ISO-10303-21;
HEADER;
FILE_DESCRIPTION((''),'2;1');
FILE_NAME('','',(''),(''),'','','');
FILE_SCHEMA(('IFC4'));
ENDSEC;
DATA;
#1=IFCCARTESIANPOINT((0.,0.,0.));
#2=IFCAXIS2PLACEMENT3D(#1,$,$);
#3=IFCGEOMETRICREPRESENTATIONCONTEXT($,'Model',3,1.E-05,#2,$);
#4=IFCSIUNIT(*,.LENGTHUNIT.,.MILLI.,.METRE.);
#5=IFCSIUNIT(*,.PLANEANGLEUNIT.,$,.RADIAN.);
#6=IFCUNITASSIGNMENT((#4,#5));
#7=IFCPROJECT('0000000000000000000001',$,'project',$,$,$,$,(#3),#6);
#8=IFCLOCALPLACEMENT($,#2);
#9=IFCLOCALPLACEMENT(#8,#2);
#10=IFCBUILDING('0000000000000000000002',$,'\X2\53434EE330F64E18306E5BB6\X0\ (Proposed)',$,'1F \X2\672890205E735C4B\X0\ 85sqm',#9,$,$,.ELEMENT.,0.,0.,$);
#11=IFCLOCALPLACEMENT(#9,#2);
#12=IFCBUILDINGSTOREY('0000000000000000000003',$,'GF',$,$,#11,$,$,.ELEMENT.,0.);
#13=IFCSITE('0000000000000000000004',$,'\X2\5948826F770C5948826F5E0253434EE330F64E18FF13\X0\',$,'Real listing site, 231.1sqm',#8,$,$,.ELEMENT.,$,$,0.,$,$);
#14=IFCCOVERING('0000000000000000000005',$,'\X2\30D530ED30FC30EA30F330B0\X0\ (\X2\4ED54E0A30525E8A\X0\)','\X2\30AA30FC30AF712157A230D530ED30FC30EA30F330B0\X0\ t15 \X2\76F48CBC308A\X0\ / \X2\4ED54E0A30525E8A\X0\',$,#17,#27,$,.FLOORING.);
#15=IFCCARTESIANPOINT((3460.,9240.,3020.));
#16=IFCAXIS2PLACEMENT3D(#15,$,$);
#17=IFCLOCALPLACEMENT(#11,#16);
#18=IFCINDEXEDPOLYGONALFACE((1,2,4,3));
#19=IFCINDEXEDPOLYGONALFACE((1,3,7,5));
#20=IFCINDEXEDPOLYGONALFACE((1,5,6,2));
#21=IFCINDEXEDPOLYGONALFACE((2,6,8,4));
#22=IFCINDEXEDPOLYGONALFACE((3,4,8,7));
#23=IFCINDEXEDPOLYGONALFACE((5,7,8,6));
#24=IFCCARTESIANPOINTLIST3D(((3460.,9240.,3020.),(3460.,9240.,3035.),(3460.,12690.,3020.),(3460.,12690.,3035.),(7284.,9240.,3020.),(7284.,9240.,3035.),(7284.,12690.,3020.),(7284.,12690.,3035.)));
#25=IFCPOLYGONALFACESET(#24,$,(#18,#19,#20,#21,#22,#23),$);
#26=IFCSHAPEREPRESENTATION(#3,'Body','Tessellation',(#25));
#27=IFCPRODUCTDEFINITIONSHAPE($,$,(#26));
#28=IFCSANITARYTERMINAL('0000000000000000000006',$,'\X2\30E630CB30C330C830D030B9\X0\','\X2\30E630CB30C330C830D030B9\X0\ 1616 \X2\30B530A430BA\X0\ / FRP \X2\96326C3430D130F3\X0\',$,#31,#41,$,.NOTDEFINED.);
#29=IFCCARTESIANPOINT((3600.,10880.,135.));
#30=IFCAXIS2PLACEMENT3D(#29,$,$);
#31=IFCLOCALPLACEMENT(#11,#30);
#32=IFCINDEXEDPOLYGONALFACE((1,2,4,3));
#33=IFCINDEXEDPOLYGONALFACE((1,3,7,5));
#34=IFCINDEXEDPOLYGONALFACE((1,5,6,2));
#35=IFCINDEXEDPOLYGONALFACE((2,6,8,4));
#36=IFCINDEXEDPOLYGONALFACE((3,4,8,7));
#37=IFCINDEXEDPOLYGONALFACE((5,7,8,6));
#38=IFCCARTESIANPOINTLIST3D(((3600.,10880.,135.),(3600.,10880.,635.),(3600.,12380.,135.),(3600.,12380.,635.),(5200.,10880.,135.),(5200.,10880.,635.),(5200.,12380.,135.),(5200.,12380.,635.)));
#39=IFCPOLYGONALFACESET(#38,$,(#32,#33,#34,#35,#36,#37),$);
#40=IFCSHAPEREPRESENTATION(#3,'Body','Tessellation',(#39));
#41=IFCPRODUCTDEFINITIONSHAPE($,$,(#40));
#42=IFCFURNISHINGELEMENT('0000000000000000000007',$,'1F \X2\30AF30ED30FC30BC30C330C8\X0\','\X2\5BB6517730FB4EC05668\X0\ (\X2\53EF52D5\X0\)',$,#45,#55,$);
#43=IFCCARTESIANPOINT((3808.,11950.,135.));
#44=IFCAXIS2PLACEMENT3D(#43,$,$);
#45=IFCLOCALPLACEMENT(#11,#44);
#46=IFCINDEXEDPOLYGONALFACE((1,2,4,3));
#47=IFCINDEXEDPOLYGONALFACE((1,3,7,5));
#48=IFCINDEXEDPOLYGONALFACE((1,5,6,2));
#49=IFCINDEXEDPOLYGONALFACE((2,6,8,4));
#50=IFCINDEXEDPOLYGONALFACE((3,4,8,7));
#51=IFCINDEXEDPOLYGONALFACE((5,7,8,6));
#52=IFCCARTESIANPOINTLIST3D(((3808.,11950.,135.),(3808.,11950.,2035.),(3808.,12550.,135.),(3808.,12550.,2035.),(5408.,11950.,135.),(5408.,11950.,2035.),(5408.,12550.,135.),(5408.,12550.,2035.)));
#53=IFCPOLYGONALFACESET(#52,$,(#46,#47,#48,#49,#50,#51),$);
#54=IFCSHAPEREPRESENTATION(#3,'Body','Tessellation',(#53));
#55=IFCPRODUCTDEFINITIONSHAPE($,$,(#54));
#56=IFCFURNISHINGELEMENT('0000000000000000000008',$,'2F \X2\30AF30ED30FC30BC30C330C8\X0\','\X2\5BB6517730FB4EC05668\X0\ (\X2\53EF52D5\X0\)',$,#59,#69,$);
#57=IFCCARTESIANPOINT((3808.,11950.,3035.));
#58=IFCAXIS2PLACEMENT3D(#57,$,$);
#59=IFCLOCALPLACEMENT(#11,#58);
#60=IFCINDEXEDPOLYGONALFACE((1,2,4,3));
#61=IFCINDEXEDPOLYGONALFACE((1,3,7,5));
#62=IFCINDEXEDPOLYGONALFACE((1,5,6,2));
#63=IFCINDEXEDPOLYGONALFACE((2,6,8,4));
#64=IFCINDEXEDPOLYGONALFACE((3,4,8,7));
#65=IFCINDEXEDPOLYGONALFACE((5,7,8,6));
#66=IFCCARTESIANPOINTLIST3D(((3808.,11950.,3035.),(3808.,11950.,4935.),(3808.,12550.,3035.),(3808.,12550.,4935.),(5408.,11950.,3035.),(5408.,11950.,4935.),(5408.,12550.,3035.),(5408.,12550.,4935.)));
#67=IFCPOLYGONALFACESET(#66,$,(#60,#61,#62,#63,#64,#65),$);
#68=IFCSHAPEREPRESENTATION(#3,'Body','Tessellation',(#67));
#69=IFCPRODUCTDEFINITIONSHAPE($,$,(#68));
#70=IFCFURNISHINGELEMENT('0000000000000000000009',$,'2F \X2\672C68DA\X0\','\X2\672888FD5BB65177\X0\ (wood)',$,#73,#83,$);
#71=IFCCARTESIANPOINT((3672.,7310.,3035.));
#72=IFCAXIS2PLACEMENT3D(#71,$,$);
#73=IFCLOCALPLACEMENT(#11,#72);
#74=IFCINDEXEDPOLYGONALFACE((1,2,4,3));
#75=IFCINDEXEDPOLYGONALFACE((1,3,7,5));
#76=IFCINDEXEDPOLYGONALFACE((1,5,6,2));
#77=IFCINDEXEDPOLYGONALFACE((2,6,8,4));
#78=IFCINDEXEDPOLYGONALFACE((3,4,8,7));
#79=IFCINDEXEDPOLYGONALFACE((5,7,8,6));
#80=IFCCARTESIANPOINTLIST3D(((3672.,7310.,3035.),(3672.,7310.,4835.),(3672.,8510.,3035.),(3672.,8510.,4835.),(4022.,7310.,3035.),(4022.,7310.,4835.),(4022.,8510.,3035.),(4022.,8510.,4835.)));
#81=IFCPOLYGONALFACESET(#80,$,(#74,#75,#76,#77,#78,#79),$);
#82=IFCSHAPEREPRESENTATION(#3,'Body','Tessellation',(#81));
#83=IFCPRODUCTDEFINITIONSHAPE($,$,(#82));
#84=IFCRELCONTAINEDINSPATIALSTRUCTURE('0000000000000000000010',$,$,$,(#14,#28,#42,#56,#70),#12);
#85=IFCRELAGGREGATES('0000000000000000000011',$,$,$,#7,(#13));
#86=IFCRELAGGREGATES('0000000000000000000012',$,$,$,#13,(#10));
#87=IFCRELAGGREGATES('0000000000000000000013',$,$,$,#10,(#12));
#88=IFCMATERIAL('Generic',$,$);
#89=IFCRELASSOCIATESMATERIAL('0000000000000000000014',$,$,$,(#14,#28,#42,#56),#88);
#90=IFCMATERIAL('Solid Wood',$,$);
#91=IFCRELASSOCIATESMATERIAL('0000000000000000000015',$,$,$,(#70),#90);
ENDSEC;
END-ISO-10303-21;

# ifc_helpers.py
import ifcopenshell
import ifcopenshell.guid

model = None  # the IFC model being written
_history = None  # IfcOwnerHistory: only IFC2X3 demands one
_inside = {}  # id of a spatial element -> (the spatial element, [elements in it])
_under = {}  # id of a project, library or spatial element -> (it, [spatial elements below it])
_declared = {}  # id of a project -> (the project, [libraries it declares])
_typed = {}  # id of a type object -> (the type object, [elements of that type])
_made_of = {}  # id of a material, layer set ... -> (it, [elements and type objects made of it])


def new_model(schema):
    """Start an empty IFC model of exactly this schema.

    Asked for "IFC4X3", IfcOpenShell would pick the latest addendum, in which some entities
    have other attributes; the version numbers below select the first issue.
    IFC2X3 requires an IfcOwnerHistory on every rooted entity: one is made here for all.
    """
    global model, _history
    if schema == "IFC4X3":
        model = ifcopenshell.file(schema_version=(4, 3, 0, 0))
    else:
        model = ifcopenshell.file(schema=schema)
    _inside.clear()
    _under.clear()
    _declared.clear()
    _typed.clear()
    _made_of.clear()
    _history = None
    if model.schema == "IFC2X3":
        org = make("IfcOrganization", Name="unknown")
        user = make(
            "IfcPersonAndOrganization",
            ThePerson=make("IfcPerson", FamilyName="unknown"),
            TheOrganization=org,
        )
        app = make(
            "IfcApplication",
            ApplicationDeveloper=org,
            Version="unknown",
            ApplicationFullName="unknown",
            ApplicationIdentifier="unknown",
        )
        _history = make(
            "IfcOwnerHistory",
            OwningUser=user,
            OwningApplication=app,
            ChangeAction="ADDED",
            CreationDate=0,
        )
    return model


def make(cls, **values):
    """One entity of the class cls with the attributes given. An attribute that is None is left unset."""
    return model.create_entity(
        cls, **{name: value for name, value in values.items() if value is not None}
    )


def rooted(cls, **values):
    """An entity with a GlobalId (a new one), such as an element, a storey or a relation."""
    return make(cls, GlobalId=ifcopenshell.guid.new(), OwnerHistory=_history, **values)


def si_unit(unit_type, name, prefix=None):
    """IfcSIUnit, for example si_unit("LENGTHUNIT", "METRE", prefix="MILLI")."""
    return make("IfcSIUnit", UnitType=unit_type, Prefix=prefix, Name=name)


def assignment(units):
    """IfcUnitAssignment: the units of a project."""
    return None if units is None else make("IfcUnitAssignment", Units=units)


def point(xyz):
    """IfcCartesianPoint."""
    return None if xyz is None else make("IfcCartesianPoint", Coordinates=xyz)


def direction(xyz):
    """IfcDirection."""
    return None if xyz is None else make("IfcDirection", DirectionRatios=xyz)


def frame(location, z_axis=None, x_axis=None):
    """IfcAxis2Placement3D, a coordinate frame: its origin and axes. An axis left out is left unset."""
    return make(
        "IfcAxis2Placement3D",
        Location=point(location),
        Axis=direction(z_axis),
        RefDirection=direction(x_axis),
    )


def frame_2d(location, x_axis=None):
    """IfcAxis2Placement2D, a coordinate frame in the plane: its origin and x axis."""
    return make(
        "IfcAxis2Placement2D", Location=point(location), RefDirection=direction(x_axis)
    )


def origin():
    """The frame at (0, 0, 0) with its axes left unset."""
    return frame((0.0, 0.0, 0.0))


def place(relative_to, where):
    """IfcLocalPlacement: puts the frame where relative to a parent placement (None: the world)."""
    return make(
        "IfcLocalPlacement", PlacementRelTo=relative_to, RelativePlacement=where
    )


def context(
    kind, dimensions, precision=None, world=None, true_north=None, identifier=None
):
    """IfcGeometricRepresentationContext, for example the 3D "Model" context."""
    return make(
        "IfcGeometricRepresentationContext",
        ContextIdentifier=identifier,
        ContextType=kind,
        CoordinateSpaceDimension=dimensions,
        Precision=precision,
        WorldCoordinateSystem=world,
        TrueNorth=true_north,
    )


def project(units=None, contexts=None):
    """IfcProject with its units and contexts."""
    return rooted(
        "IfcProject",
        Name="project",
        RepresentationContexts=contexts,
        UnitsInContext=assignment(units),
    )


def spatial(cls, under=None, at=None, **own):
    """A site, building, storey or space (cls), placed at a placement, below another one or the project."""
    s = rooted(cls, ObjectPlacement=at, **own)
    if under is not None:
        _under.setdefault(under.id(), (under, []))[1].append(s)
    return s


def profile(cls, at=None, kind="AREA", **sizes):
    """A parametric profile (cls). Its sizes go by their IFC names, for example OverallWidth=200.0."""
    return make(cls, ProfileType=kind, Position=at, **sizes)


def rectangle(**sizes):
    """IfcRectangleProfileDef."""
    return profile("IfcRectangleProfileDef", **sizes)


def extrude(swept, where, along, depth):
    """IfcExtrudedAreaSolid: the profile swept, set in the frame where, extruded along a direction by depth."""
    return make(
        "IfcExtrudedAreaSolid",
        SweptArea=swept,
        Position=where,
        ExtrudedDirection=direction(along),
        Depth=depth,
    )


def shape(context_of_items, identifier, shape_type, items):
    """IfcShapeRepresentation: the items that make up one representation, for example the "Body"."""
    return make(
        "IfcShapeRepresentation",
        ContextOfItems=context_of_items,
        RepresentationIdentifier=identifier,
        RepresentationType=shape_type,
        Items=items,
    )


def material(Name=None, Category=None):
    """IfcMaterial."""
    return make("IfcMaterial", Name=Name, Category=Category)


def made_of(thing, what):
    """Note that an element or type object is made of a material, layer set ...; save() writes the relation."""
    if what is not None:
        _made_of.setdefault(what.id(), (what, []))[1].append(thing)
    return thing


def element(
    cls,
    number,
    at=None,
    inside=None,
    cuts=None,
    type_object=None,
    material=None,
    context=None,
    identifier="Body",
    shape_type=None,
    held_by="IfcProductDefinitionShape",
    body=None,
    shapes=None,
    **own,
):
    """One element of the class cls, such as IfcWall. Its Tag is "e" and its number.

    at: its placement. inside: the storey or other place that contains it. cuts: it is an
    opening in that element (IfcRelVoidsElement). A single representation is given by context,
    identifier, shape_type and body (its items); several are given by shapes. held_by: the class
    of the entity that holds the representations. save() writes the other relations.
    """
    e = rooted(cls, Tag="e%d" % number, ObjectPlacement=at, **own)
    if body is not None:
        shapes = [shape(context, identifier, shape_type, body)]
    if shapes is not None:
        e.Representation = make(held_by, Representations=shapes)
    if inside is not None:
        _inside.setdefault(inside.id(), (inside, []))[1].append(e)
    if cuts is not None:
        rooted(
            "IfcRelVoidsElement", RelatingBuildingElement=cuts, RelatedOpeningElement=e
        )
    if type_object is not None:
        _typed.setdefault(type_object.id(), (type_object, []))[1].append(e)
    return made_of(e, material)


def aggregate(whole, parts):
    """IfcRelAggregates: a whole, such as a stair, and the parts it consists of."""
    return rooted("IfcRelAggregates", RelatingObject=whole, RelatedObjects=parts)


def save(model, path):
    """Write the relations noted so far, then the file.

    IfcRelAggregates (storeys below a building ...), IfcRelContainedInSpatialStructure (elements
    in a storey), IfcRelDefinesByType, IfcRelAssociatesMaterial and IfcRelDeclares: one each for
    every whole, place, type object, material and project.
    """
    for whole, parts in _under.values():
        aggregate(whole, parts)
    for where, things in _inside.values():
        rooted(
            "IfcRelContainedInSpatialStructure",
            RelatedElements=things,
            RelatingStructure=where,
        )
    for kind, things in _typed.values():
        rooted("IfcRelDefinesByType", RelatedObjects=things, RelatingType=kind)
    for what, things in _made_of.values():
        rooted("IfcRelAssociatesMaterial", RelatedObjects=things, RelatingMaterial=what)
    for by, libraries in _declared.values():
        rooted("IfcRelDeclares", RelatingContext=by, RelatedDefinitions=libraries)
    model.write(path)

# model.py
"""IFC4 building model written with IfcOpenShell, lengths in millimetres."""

from ifc_helpers import new_model, si_unit, frame, frame_2d, origin, place, context, project, spatial, rectangle, extrude, material, element, save


model = new_model("IFC4")

# Units and contexts
model_context = context("Model", 3, precision=1e-05, world=origin())
ifc_project = project(units=[si_unit("LENGTHUNIT", "METRE", prefix="MILLI"), si_unit("PLANEANGLEUNIT", "RADIAN")], contexts=[model_context])

# Site, building, storey
site_placement = place(None, origin())
site = spatial("IfcSite", under=ifc_project, at=site_placement, Name="奈良県奈良市千代ヶ丘３", ObjectType="Real listing site, 231.1sqm", CompositionType="ELEMENT", RefElevation=0.0)
building_placement = place(site_placement, origin())
building = spatial("IfcBuilding", under=site, at=building_placement, Name="千代ヶ丘の家 (Proposed)", ObjectType="1F 木造平屋 85sqm", CompositionType="ELEMENT", ElevationOfRefHeight=0.0, ElevationOfTerrain=0.0)
storey_placement = place(building_placement, origin())
storey = spatial("IfcBuildingStorey", under=building, at=storey_placement, Name="GF", CompositionType="ELEMENT", Elevation=0.0)

# Shared definitions
ifc_material_1 = material(Name="Solid Wood")

# Covering
ifc_material_2 = material(Name="Generic")
covering_1_placement = place(storey_placement, frame((3460.0, 9240.0, 3020.0)))
element("IfcCovering", 1, at=covering_1_placement, inside=storey, material=ifc_material_2, Name="フローリング (仕上げ床)", Description="オーク無垢フローリング t15 直貼り / 仕上げ床", PredefinedType="FLOORING", context=model_context, shape_type="SweptSolid", body=[
    extrude(rectangle(XDim=3824.0, YDim=3450.0, at=frame_2d((1912.0, 1725.0))), frame((3460.0, 9240.0, 3020.0)), (0.0, 0.0, 1.0), 15.0),
])

# Sanitary terminal
sanitary_terminal_placement = place(storey_placement, frame((3600.0, 10880.0, 135.0)))
element("IfcSanitaryTerminal", 2, at=sanitary_terminal_placement, inside=storey, material=ifc_material_2, Name="ユニットバス", Description="ユニットバス 1616 サイズ / FRP 防水パン", PredefinedType="NOTDEFINED", context=model_context, shape_type="SweptSolid", body=[
    extrude(rectangle(XDim=1600.0, YDim=1500.0, at=frame_2d((800.0, 750.0))), frame((3600.0, 10880.0, 135.0)), (0.0, 0.0, 1.0), 500.0),
])

# Furnishing elements
furnishing_1_placement = place(storey_placement, frame((3808.0, 11950.0, 135.0)))
element("IfcFurnishingElement", 3, at=furnishing_1_placement, inside=storey, material=ifc_material_2, Name="1F クローゼット", Description="家具・什器 (可動)", context=model_context, shape_type="SweptSolid", body=[
    extrude(rectangle(XDim=1600.0, YDim=600.0, at=frame_2d((800.0, 300.0))), frame((3808.0, 11950.0, 135.0)), (0.0, 0.0, 1.0), 1900.0),
])
furnishing_2_placement = place(storey_placement, frame((3808.0, 11950.0, 3035.0)))
element("IfcFurnishingElement", 4, at=furnishing_2_placement, inside=storey, material=ifc_material_2, Name="2F クローゼット", Description="家具・什器 (可動)", context=model_context, shape_type="SweptSolid", body=[
    extrude(rectangle(XDim=1600.0, YDim=600.0, at=frame_2d((800.0, 300.0))), frame((3808.0, 11950.0, 3035.0)), (0.0, 0.0, 1.0), 1900.0),
])
furnishing_3_placement = place(storey_placement, frame((3672.0, 7310.0, 3035.0)))
element("IfcFurnishingElement", 5, at=furnishing_3_placement, inside=storey, material=ifc_material_1, Name="2F 本棚", Description="木製家具 (wood)", context=model_context, shape_type="SweptSolid", body=[
    extrude(rectangle(XDim=350.0, YDim=1200.0, at=frame_2d((175.0, 600.0))), frame((3672.0, 7310.0, 3035.0)), (0.0, 0.0, 1.0), 1800.0),
])

save(model, "model.ifc")
